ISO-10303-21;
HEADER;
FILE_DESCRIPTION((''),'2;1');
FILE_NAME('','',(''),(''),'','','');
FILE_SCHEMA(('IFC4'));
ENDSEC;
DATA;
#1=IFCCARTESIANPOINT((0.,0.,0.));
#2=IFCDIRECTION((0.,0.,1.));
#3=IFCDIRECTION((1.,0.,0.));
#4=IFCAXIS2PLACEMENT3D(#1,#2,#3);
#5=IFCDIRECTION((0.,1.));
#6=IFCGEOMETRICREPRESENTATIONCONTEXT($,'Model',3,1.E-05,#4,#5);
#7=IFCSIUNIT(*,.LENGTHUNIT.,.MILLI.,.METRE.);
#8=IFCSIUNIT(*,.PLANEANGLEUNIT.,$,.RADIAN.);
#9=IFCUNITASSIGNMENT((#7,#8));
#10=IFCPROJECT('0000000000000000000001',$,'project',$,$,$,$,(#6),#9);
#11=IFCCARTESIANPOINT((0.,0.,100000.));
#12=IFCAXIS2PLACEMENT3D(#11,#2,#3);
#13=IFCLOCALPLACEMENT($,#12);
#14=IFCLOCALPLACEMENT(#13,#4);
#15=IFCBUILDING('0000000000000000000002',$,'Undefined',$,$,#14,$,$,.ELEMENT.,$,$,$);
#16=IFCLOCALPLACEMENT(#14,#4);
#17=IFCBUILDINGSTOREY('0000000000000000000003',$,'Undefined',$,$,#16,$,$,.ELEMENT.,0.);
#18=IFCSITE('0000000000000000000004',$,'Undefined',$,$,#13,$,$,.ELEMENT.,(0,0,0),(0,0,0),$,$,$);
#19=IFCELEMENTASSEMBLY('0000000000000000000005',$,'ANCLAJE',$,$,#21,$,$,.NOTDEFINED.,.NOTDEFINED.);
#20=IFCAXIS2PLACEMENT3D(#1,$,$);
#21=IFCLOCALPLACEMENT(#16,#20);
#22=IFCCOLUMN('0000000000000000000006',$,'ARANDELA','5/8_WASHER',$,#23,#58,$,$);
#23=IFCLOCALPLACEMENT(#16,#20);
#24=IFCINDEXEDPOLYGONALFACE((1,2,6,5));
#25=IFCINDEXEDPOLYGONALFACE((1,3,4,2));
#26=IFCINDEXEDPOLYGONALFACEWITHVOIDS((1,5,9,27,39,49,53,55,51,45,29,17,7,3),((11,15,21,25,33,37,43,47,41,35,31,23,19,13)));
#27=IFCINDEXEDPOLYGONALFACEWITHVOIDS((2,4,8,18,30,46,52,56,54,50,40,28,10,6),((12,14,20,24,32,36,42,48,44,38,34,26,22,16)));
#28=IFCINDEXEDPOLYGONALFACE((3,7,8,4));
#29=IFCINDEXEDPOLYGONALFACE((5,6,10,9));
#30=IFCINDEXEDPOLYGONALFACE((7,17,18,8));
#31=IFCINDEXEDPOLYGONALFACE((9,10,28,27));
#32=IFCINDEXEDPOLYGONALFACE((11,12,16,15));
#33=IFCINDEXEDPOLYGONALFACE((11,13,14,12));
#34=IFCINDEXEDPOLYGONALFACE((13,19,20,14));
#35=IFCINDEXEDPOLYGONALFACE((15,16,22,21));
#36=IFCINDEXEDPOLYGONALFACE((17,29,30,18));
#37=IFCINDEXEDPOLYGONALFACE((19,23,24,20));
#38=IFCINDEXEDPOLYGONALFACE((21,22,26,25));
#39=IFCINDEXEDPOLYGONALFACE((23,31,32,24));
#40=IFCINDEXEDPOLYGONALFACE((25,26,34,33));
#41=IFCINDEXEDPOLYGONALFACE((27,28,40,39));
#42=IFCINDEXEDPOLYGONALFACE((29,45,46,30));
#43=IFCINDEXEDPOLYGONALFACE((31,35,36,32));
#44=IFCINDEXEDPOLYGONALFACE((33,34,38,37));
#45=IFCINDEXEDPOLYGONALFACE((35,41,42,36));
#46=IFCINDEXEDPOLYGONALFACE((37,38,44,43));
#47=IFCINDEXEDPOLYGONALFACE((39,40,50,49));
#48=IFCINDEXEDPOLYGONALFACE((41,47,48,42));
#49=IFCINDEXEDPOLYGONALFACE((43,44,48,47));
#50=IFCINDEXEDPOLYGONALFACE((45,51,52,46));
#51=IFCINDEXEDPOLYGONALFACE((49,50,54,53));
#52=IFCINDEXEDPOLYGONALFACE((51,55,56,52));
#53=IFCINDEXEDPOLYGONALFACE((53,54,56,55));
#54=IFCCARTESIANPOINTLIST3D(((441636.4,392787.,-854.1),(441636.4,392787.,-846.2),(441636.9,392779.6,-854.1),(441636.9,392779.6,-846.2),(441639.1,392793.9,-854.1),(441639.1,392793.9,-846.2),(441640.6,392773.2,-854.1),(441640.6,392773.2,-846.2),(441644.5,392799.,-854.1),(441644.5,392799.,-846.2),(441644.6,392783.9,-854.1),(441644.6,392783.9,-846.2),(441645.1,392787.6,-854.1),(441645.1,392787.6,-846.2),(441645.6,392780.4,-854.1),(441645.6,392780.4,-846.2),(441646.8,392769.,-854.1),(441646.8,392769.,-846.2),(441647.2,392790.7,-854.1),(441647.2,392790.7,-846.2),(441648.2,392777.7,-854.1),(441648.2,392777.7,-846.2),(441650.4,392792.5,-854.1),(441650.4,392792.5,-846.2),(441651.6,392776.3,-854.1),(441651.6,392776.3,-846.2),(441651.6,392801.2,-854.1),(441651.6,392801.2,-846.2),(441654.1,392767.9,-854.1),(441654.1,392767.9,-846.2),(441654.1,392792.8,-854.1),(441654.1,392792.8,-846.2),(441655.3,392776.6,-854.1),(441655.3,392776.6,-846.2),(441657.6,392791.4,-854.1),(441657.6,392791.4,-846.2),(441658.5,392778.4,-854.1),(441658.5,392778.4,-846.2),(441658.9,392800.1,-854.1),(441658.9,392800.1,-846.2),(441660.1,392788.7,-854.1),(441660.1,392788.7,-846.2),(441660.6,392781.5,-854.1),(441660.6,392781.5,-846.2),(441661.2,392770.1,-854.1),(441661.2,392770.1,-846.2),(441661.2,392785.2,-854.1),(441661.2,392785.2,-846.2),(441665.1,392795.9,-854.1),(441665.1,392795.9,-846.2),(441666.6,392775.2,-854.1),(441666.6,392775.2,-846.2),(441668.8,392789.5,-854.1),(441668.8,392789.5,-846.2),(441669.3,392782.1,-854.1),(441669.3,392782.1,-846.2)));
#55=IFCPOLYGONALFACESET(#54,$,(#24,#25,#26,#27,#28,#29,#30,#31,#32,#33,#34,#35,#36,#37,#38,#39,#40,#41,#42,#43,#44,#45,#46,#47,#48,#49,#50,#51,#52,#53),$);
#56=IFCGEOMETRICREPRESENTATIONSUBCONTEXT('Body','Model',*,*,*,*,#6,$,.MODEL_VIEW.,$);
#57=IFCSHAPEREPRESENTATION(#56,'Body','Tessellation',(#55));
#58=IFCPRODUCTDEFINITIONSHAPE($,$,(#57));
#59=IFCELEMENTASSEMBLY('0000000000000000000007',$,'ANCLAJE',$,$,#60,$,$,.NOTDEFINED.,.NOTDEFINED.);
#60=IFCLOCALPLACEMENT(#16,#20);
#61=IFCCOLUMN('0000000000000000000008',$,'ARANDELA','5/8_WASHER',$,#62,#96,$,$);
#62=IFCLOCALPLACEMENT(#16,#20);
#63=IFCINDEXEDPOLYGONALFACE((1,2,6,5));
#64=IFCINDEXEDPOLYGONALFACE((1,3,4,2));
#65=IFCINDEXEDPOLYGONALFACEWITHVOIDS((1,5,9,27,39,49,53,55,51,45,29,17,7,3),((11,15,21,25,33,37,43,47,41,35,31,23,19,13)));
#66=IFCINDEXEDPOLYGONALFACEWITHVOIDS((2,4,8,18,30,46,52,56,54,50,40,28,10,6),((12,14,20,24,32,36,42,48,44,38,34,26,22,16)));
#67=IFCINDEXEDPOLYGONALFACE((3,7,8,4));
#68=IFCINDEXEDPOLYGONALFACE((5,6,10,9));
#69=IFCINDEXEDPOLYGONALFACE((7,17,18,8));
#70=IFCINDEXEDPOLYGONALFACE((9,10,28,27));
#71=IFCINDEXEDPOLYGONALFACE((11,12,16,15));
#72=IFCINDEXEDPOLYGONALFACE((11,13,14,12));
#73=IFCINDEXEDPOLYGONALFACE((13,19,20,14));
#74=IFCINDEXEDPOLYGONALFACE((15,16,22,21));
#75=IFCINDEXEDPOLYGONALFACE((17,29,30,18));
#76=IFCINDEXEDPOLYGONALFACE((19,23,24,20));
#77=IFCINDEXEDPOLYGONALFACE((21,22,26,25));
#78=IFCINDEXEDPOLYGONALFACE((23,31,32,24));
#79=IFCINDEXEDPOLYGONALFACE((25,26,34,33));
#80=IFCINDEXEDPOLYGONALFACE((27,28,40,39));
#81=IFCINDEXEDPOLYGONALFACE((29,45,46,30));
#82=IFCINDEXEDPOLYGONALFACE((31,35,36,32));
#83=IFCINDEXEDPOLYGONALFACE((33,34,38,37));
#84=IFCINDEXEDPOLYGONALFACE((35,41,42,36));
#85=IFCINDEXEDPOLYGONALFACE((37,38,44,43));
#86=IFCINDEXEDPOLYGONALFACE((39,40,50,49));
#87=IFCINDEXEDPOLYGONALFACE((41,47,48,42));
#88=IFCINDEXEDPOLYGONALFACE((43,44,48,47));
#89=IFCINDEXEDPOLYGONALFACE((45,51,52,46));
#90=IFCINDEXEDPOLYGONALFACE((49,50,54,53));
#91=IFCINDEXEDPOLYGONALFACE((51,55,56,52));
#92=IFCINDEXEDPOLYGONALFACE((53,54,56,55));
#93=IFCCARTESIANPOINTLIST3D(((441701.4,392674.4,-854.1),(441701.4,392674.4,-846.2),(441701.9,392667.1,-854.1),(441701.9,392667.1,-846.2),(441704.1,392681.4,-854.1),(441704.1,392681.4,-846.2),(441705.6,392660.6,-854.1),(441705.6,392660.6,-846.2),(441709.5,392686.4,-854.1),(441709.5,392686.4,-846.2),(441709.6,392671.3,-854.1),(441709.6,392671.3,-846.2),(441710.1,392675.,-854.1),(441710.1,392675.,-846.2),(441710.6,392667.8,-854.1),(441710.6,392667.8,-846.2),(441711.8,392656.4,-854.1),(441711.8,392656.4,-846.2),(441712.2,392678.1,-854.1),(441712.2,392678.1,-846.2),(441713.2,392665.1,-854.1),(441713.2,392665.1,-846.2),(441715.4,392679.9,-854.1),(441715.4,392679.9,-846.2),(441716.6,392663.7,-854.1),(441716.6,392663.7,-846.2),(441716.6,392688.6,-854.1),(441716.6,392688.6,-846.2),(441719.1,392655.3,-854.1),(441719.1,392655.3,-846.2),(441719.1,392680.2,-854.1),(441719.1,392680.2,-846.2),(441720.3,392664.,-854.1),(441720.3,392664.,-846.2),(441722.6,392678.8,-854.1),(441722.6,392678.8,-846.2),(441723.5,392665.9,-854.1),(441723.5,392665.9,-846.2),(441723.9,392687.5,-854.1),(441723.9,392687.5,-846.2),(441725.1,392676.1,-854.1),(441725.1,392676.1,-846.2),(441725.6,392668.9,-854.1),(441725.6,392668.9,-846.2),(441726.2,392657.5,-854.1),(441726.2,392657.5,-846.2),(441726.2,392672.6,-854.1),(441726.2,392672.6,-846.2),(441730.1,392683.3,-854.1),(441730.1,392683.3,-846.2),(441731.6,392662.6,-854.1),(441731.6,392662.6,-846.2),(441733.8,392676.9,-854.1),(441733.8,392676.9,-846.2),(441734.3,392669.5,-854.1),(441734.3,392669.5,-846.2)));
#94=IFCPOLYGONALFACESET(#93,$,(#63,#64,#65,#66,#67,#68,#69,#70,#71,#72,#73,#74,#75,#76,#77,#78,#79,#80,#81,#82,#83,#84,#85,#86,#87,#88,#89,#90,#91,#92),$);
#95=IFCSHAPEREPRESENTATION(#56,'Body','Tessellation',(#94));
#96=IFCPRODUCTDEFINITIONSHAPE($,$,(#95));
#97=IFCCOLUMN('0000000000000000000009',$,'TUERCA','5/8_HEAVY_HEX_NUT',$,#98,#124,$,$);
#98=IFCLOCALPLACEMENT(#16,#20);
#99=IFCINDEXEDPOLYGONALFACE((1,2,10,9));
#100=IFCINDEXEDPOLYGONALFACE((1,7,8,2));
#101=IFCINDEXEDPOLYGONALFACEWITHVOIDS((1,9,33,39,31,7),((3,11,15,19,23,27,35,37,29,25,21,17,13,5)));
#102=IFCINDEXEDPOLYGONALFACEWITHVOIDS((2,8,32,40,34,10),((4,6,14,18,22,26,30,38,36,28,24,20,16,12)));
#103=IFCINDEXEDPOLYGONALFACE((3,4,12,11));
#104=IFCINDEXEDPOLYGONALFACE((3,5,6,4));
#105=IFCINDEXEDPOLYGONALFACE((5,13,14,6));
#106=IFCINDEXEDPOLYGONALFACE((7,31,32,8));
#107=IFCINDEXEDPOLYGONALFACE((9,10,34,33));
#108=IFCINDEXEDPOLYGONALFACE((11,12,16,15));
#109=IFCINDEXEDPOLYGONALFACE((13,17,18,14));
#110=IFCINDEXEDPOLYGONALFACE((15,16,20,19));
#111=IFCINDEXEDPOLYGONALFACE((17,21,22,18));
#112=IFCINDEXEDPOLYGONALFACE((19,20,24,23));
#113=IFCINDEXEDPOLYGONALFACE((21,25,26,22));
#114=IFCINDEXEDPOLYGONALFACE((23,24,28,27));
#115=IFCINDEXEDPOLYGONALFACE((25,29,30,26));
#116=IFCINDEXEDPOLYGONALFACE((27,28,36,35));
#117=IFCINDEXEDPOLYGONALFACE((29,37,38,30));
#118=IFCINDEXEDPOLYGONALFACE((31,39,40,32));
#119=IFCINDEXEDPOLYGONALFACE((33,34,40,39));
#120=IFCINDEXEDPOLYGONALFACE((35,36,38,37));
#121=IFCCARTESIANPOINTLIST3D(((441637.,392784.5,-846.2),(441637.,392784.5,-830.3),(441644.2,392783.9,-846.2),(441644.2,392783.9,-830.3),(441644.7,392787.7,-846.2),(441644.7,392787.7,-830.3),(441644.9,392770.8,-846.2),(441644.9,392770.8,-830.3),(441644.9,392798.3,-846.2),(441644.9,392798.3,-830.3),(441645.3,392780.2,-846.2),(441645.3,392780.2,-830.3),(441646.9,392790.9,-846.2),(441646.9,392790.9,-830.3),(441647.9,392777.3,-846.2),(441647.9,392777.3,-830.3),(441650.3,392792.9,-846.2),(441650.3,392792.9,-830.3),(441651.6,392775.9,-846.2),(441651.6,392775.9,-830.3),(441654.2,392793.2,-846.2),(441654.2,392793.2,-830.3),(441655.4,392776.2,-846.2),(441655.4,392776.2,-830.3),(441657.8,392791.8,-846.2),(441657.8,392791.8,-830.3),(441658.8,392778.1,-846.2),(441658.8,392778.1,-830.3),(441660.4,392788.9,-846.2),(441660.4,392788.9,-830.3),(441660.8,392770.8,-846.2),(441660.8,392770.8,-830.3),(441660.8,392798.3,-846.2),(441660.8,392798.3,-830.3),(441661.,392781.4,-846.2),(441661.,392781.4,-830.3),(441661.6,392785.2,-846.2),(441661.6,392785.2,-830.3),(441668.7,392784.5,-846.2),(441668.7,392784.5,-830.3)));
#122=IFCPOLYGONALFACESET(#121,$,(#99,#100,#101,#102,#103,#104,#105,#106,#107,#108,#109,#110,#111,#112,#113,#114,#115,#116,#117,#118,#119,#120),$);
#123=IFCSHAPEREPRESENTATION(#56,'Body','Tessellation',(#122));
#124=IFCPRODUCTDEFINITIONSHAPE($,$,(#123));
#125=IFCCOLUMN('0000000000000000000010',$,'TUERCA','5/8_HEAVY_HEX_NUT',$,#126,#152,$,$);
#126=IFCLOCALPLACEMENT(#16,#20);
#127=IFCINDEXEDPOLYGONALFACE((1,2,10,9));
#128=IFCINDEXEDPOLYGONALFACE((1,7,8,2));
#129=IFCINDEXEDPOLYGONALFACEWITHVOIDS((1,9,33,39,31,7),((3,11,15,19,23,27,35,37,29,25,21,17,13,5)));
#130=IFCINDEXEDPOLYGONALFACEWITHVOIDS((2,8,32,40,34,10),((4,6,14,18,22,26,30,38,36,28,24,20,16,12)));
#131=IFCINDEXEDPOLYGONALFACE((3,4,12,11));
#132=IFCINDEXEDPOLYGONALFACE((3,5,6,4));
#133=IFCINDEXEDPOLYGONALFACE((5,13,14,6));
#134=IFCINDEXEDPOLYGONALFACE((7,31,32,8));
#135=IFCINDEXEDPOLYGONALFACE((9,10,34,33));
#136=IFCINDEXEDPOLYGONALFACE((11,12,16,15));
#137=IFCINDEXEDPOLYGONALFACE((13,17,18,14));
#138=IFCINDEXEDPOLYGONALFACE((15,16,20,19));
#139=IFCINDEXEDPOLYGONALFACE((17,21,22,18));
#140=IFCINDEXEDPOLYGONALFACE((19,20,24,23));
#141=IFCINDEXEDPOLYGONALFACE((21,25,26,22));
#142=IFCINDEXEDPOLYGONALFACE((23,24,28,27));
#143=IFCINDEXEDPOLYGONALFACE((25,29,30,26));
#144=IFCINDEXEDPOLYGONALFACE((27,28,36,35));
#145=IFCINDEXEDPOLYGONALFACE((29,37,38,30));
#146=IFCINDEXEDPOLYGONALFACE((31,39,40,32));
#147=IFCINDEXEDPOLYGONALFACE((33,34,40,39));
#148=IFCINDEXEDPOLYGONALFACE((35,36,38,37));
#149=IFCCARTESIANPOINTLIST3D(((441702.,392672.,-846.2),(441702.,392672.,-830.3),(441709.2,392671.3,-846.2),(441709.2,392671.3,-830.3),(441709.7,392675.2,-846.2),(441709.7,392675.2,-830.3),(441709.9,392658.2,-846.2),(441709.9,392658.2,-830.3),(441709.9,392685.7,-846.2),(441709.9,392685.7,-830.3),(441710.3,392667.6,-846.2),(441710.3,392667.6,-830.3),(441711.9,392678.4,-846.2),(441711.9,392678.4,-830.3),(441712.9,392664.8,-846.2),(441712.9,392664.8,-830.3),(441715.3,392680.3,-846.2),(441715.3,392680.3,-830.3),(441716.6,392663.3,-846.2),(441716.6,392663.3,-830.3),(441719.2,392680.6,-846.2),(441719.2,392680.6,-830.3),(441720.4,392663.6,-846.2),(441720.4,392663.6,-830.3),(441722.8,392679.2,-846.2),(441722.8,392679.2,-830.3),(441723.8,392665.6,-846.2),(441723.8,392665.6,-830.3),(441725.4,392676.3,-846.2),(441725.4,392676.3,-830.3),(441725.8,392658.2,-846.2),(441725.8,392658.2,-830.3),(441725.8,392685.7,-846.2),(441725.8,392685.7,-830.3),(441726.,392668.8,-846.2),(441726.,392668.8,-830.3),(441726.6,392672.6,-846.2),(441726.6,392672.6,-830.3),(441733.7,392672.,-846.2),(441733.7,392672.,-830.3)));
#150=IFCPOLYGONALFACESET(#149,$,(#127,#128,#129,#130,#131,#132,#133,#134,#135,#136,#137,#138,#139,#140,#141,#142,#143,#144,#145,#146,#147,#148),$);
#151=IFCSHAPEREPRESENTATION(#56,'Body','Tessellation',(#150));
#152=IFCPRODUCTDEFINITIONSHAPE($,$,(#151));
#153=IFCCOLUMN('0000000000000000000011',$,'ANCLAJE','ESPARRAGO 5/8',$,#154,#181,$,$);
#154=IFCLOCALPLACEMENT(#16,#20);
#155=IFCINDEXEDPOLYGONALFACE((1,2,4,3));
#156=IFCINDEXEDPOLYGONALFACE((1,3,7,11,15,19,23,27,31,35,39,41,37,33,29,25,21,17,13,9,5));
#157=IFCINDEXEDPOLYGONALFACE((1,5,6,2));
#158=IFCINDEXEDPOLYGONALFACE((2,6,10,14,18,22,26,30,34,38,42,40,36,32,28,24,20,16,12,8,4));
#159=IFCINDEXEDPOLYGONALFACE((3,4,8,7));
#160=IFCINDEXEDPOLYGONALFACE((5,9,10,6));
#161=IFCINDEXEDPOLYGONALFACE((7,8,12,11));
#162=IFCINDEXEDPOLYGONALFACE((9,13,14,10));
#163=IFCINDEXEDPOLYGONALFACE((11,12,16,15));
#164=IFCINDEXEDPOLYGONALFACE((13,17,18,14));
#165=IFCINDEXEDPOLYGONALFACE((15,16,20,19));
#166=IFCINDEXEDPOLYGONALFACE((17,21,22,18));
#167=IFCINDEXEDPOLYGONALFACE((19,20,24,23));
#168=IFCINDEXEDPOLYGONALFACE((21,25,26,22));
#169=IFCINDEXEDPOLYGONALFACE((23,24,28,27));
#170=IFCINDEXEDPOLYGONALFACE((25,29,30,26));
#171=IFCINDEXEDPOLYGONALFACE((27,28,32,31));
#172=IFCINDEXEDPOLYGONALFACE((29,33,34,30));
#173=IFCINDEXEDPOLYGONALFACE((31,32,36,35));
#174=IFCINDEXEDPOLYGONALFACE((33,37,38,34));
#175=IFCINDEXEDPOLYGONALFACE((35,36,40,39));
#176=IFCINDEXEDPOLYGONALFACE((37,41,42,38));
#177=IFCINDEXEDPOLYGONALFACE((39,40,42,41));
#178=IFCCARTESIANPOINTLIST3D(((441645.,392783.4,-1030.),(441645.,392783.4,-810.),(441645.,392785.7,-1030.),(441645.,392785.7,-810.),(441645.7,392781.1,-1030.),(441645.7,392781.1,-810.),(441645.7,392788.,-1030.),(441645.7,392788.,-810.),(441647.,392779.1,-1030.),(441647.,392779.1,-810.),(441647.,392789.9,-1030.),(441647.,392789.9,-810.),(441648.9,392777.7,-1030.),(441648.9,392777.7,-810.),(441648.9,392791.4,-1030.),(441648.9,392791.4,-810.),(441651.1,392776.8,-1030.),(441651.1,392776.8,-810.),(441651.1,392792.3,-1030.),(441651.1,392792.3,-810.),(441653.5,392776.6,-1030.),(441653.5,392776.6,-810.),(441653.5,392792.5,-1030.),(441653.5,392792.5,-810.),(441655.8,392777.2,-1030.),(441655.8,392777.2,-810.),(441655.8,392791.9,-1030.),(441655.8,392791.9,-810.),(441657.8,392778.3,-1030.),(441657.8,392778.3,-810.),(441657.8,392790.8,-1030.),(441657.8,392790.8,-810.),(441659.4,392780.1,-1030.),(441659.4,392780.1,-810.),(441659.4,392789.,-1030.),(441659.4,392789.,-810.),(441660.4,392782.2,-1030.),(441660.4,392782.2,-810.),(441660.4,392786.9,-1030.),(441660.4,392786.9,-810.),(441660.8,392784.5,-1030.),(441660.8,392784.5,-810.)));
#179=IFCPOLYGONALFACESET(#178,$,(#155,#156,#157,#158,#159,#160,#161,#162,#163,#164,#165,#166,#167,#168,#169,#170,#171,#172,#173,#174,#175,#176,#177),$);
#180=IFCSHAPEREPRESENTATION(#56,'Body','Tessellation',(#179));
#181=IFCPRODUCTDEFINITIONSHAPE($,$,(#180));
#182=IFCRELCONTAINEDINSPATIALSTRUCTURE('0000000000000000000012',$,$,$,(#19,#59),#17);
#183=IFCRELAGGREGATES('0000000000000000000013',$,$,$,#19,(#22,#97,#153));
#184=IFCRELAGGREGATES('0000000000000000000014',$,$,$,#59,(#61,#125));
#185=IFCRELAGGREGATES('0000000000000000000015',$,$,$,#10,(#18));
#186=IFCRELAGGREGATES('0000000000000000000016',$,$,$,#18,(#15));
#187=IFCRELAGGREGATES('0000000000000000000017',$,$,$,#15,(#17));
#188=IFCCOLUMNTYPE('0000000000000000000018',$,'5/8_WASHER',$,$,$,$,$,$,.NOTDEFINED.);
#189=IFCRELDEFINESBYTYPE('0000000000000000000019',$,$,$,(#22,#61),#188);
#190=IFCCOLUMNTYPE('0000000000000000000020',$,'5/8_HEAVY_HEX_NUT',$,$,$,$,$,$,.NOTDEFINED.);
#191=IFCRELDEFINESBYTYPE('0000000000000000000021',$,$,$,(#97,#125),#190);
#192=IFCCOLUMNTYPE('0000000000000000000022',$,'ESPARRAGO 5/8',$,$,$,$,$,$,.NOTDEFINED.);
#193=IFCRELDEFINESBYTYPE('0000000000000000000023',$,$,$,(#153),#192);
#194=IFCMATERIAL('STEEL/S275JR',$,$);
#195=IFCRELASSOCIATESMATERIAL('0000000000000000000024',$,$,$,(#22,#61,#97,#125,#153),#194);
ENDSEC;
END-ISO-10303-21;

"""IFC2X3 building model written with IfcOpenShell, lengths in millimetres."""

from ifc_helpers import new_model, si_unit, direction, frame, origin_with_axes, origin_2d_with_axis, place, context, subcontext, project, spatial, polyline, circle, outline, extrude, material, type_object, element, aggregate, save


model = new_model("IFC2X3")

# Units and contexts
model_context = context("Model", 3, precision=1e-05, world=origin_with_axes(), true_north=direction((0.0, 1.0)))
body_context = subcontext(model_context, "Body", "Model", "MODEL_VIEW")
ifc_project = project(units=[si_unit("LENGTHUNIT", "METRE", prefix="MILLI"), si_unit("PLANEANGLEUNIT", "RADIAN")], contexts=[model_context])

# Site, building, storey
site_placement = place(None, frame((0.0, 0.0, 100000.0), z_axis=(0.0, 0.0, 1.0), x_axis=(1.0, 0.0, 0.0)))
site = spatial("IfcSite", under=ifc_project, at=site_placement, Name="Undefined", CompositionType="ELEMENT", RefLatitude=(0, 0, 0), RefLongitude=(0, 0, 0))
building_placement = place(site_placement, origin_with_axes())
building = spatial("IfcBuilding", under=site, at=building_placement, Name="Undefined", CompositionType="ELEMENT")
storey_placement = place(building_placement, origin_with_axes())
storey = spatial("IfcBuildingStorey", under=building, at=storey_placement, Name="Undefined", CompositionType="ELEMENT", Elevation=0.0)

# Element assemblies, columns
assembly_1_placement = place(storey_placement, origin_with_axes())
assembly_1 = element("IfcElementAssembly", 1, at=assembly_1_placement, inside=storey, Name="ANCLAJE", AssemblyPlace="NOTDEFINED", PredefinedType="NOTDEFINED")
ifc_material_1 = material(Name="STEEL/S275JR")
column_type_1 = type_object("IfcColumnType", Name="5/8_WASHER", PredefinedType="NOTDEFINED")
column_1_placement = place(assembly_1_placement, frame((441652.9, 392784.5, -846.2), z_axis=(0.0, 0.0, -1.0), x_axis=(-0.866025, -0.5, 0.0)))
column_1 = element("IfcColumn", 2, at=column_1_placement, type_object=column_type_1, material=ifc_material_1, Name="ARANDELA", Description="5/8_WASHER", context=body_context, shape_type="SweptSolid", body=[
    extrude(outline(polyline([(10.4, 13.0), (15.0, 7.2), (16.7, 0.0), (15.0, -7.2), (10.4, -13.0), (3.7, -16.3), (-3.7, -16.3), (-10.4, -13.0), (-15.0, -7.2), (-16.7, 0.0), (-15.0, 7.2), (-10.4, 13.0), (-3.7, 16.3), (3.7, 16.3), (10.4, 13.0)]), holes=[polyline([(6.5, -5.2), (8.1, -1.9), (8.1, 1.9), (6.5, 5.2), (3.6, 7.5), (0.0, 8.3), (-3.6, 7.5), (-6.5, 5.2), (-8.1, 1.9), (-8.1, -1.9), (-6.5, -5.2), (-3.6, -7.5), (0.0, -8.3), (3.6, -7.5), (6.5, -5.2)])]), frame((0.0, 0.0, 7.9), z_axis=(0.0, 0.0, -1.0), x_axis=(0.0, 1.0, 0.0)), (0.0, 0.0, 1.0), 7.9),
])
assembly_2_placement = place(storey_placement, origin_with_axes())
assembly_2 = element("IfcElementAssembly", 3, at=assembly_2_placement, inside=storey, Name="ANCLAJE", AssemblyPlace="NOTDEFINED", PredefinedType="NOTDEFINED")
column_2_placement = place(assembly_2_placement, frame((441717.9, 392672.0, -846.2), z_axis=(0.0, 0.0, -1.0), x_axis=(0.866025, 0.5, 0.0)))
column_2 = element("IfcColumn", 4, at=column_2_placement, type_object=column_type_1, material=ifc_material_1, Name="ARANDELA", Description="5/8_WASHER", context=body_context, shape_type="SweptSolid", body=[
    extrude(outline(polyline([(10.4, 13.0), (15.0, 7.2), (16.7, 0.0), (15.0, -7.2), (10.4, -13.0), (3.7, -16.3), (-3.7, -16.3), (-10.4, -13.0), (-15.0, -7.2), (-16.7, 0.0), (-15.0, 7.2), (-10.4, 13.0), (-3.7, 16.3), (3.7, 16.3), (10.4, 13.0)]), holes=[polyline([(6.5, -5.2), (8.1, -1.9), (8.1, 1.9), (6.5, 5.2), (3.6, 7.5), (0.0, 8.3), (-3.6, 7.5), (-6.5, 5.2), (-8.1, 1.9), (-8.1, -1.9), (-6.5, -5.2), (-3.6, -7.5), (0.0, -8.3), (3.6, -7.5), (6.5, -5.2)])]), frame((0.0, 0.0, 7.9), z_axis=(0.0, 0.0, -1.0), x_axis=(0.0, 1.0, 0.0)), (0.0, 0.0, 1.0), 7.9),
])

# Columns
column_type_2 = type_object("IfcColumnType", Name="5/8_HEAVY_HEX_NUT", PredefinedType="NOTDEFINED")
column_3_placement = place(assembly_1_placement, frame((441652.9, 392784.5, -830.3), z_axis=(0.0, 0.0, -1.0), x_axis=(-0.866025, -0.5, 0.0)))
column_3 = element("IfcColumn", 5, at=column_3_placement, type_object=column_type_2, material=ifc_material_1, Name="TUERCA", Description="5/8_HEAVY_HEX_NUT", context=body_context, shape_type="SweptSolid", body=[
    extrude(outline(polyline([(-7.9, -13.7), (-15.9, 0.0), (-7.9, 13.7), (7.9, 13.7), (15.9, 0.0), (7.9, -13.7), (-7.9, -13.7)]), holes=[polyline([(3.8, 7.9), (0.0, 8.7), (-3.8, 7.9), (-6.8, 5.4), (-8.5, 1.9), (-8.5, -1.9), (-6.8, -5.4), (-3.8, -7.9), (0.0, -8.7), (3.8, -7.9), (6.8, -5.4), (8.5, -1.9), (8.5, 1.9), (6.8, 5.4), (3.8, 7.9)])]), frame((0.0, 0.0, 15.9), z_axis=(0.0, 0.0, -1.0), x_axis=(0.0, 1.0, 0.0)), (0.0, 0.0, 1.0), 15.9),
])
column_4_placement = place(assembly_2_placement, frame((441717.9, 392672.0, -830.3), z_axis=(0.0, 0.0, -1.0), x_axis=(0.866025, 0.5, 0.0)))
column_4 = element("IfcColumn", 6, at=column_4_placement, type_object=column_type_2, material=ifc_material_1, Name="TUERCA", Description="5/8_HEAVY_HEX_NUT", context=body_context, shape_type="SweptSolid", body=[
    extrude(outline(polyline([(-7.9, -13.7), (-15.9, 0.0), (-7.9, 13.7), (7.9, 13.7), (15.9, 0.0), (7.9, -13.7), (-7.9, -13.7)]), holes=[polyline([(3.8, 7.9), (0.0, 8.7), (-3.8, 7.9), (-6.8, 5.4), (-8.5, 1.9), (-8.5, -1.9), (-6.8, -5.4), (-3.8, -7.9), (0.0, -8.7), (3.8, -7.9), (6.8, -5.4), (8.5, -1.9), (8.5, 1.9), (6.8, 5.4), (3.8, 7.9)])]), frame((0.0, 0.0, 15.9), z_axis=(0.0, 0.0, -1.0), x_axis=(0.0, 1.0, 0.0)), (0.0, 0.0, 1.0), 15.9),
])
column_type_3 = type_object("IfcColumnType", Name="ESPARRAGO 5/8", PredefinedType="NOTDEFINED")
column_5_placement = place(assembly_1_placement, frame((441652.9, 392784.5, -810.0), z_axis=(0.0, 0.0, -1.0), x_axis=(-0.866025, -0.5, 0.0)))
column_5 = element("IfcColumn", 7, at=column_5_placement, type_object=column_type_3, material=ifc_material_1, Name="ANCLAJE", Description="ESPARRAGO 5/8", context=body_context, shape_type="SweptSolid", body=[
    extrude(circle(Radius=7.9, at=origin_2d_with_axis()), frame((0.0, 0.0, 220.0), z_axis=(0.0, 0.0, -1.0), x_axis=(0.0, 1.0, 0.0)), (0.0, 0.0, 1.0), 220.0),
])
aggregate(assembly_1, [column_1, column_3, column_5])
aggregate(assembly_2, [column_2, column_4])

save(model, "model.ifc")
